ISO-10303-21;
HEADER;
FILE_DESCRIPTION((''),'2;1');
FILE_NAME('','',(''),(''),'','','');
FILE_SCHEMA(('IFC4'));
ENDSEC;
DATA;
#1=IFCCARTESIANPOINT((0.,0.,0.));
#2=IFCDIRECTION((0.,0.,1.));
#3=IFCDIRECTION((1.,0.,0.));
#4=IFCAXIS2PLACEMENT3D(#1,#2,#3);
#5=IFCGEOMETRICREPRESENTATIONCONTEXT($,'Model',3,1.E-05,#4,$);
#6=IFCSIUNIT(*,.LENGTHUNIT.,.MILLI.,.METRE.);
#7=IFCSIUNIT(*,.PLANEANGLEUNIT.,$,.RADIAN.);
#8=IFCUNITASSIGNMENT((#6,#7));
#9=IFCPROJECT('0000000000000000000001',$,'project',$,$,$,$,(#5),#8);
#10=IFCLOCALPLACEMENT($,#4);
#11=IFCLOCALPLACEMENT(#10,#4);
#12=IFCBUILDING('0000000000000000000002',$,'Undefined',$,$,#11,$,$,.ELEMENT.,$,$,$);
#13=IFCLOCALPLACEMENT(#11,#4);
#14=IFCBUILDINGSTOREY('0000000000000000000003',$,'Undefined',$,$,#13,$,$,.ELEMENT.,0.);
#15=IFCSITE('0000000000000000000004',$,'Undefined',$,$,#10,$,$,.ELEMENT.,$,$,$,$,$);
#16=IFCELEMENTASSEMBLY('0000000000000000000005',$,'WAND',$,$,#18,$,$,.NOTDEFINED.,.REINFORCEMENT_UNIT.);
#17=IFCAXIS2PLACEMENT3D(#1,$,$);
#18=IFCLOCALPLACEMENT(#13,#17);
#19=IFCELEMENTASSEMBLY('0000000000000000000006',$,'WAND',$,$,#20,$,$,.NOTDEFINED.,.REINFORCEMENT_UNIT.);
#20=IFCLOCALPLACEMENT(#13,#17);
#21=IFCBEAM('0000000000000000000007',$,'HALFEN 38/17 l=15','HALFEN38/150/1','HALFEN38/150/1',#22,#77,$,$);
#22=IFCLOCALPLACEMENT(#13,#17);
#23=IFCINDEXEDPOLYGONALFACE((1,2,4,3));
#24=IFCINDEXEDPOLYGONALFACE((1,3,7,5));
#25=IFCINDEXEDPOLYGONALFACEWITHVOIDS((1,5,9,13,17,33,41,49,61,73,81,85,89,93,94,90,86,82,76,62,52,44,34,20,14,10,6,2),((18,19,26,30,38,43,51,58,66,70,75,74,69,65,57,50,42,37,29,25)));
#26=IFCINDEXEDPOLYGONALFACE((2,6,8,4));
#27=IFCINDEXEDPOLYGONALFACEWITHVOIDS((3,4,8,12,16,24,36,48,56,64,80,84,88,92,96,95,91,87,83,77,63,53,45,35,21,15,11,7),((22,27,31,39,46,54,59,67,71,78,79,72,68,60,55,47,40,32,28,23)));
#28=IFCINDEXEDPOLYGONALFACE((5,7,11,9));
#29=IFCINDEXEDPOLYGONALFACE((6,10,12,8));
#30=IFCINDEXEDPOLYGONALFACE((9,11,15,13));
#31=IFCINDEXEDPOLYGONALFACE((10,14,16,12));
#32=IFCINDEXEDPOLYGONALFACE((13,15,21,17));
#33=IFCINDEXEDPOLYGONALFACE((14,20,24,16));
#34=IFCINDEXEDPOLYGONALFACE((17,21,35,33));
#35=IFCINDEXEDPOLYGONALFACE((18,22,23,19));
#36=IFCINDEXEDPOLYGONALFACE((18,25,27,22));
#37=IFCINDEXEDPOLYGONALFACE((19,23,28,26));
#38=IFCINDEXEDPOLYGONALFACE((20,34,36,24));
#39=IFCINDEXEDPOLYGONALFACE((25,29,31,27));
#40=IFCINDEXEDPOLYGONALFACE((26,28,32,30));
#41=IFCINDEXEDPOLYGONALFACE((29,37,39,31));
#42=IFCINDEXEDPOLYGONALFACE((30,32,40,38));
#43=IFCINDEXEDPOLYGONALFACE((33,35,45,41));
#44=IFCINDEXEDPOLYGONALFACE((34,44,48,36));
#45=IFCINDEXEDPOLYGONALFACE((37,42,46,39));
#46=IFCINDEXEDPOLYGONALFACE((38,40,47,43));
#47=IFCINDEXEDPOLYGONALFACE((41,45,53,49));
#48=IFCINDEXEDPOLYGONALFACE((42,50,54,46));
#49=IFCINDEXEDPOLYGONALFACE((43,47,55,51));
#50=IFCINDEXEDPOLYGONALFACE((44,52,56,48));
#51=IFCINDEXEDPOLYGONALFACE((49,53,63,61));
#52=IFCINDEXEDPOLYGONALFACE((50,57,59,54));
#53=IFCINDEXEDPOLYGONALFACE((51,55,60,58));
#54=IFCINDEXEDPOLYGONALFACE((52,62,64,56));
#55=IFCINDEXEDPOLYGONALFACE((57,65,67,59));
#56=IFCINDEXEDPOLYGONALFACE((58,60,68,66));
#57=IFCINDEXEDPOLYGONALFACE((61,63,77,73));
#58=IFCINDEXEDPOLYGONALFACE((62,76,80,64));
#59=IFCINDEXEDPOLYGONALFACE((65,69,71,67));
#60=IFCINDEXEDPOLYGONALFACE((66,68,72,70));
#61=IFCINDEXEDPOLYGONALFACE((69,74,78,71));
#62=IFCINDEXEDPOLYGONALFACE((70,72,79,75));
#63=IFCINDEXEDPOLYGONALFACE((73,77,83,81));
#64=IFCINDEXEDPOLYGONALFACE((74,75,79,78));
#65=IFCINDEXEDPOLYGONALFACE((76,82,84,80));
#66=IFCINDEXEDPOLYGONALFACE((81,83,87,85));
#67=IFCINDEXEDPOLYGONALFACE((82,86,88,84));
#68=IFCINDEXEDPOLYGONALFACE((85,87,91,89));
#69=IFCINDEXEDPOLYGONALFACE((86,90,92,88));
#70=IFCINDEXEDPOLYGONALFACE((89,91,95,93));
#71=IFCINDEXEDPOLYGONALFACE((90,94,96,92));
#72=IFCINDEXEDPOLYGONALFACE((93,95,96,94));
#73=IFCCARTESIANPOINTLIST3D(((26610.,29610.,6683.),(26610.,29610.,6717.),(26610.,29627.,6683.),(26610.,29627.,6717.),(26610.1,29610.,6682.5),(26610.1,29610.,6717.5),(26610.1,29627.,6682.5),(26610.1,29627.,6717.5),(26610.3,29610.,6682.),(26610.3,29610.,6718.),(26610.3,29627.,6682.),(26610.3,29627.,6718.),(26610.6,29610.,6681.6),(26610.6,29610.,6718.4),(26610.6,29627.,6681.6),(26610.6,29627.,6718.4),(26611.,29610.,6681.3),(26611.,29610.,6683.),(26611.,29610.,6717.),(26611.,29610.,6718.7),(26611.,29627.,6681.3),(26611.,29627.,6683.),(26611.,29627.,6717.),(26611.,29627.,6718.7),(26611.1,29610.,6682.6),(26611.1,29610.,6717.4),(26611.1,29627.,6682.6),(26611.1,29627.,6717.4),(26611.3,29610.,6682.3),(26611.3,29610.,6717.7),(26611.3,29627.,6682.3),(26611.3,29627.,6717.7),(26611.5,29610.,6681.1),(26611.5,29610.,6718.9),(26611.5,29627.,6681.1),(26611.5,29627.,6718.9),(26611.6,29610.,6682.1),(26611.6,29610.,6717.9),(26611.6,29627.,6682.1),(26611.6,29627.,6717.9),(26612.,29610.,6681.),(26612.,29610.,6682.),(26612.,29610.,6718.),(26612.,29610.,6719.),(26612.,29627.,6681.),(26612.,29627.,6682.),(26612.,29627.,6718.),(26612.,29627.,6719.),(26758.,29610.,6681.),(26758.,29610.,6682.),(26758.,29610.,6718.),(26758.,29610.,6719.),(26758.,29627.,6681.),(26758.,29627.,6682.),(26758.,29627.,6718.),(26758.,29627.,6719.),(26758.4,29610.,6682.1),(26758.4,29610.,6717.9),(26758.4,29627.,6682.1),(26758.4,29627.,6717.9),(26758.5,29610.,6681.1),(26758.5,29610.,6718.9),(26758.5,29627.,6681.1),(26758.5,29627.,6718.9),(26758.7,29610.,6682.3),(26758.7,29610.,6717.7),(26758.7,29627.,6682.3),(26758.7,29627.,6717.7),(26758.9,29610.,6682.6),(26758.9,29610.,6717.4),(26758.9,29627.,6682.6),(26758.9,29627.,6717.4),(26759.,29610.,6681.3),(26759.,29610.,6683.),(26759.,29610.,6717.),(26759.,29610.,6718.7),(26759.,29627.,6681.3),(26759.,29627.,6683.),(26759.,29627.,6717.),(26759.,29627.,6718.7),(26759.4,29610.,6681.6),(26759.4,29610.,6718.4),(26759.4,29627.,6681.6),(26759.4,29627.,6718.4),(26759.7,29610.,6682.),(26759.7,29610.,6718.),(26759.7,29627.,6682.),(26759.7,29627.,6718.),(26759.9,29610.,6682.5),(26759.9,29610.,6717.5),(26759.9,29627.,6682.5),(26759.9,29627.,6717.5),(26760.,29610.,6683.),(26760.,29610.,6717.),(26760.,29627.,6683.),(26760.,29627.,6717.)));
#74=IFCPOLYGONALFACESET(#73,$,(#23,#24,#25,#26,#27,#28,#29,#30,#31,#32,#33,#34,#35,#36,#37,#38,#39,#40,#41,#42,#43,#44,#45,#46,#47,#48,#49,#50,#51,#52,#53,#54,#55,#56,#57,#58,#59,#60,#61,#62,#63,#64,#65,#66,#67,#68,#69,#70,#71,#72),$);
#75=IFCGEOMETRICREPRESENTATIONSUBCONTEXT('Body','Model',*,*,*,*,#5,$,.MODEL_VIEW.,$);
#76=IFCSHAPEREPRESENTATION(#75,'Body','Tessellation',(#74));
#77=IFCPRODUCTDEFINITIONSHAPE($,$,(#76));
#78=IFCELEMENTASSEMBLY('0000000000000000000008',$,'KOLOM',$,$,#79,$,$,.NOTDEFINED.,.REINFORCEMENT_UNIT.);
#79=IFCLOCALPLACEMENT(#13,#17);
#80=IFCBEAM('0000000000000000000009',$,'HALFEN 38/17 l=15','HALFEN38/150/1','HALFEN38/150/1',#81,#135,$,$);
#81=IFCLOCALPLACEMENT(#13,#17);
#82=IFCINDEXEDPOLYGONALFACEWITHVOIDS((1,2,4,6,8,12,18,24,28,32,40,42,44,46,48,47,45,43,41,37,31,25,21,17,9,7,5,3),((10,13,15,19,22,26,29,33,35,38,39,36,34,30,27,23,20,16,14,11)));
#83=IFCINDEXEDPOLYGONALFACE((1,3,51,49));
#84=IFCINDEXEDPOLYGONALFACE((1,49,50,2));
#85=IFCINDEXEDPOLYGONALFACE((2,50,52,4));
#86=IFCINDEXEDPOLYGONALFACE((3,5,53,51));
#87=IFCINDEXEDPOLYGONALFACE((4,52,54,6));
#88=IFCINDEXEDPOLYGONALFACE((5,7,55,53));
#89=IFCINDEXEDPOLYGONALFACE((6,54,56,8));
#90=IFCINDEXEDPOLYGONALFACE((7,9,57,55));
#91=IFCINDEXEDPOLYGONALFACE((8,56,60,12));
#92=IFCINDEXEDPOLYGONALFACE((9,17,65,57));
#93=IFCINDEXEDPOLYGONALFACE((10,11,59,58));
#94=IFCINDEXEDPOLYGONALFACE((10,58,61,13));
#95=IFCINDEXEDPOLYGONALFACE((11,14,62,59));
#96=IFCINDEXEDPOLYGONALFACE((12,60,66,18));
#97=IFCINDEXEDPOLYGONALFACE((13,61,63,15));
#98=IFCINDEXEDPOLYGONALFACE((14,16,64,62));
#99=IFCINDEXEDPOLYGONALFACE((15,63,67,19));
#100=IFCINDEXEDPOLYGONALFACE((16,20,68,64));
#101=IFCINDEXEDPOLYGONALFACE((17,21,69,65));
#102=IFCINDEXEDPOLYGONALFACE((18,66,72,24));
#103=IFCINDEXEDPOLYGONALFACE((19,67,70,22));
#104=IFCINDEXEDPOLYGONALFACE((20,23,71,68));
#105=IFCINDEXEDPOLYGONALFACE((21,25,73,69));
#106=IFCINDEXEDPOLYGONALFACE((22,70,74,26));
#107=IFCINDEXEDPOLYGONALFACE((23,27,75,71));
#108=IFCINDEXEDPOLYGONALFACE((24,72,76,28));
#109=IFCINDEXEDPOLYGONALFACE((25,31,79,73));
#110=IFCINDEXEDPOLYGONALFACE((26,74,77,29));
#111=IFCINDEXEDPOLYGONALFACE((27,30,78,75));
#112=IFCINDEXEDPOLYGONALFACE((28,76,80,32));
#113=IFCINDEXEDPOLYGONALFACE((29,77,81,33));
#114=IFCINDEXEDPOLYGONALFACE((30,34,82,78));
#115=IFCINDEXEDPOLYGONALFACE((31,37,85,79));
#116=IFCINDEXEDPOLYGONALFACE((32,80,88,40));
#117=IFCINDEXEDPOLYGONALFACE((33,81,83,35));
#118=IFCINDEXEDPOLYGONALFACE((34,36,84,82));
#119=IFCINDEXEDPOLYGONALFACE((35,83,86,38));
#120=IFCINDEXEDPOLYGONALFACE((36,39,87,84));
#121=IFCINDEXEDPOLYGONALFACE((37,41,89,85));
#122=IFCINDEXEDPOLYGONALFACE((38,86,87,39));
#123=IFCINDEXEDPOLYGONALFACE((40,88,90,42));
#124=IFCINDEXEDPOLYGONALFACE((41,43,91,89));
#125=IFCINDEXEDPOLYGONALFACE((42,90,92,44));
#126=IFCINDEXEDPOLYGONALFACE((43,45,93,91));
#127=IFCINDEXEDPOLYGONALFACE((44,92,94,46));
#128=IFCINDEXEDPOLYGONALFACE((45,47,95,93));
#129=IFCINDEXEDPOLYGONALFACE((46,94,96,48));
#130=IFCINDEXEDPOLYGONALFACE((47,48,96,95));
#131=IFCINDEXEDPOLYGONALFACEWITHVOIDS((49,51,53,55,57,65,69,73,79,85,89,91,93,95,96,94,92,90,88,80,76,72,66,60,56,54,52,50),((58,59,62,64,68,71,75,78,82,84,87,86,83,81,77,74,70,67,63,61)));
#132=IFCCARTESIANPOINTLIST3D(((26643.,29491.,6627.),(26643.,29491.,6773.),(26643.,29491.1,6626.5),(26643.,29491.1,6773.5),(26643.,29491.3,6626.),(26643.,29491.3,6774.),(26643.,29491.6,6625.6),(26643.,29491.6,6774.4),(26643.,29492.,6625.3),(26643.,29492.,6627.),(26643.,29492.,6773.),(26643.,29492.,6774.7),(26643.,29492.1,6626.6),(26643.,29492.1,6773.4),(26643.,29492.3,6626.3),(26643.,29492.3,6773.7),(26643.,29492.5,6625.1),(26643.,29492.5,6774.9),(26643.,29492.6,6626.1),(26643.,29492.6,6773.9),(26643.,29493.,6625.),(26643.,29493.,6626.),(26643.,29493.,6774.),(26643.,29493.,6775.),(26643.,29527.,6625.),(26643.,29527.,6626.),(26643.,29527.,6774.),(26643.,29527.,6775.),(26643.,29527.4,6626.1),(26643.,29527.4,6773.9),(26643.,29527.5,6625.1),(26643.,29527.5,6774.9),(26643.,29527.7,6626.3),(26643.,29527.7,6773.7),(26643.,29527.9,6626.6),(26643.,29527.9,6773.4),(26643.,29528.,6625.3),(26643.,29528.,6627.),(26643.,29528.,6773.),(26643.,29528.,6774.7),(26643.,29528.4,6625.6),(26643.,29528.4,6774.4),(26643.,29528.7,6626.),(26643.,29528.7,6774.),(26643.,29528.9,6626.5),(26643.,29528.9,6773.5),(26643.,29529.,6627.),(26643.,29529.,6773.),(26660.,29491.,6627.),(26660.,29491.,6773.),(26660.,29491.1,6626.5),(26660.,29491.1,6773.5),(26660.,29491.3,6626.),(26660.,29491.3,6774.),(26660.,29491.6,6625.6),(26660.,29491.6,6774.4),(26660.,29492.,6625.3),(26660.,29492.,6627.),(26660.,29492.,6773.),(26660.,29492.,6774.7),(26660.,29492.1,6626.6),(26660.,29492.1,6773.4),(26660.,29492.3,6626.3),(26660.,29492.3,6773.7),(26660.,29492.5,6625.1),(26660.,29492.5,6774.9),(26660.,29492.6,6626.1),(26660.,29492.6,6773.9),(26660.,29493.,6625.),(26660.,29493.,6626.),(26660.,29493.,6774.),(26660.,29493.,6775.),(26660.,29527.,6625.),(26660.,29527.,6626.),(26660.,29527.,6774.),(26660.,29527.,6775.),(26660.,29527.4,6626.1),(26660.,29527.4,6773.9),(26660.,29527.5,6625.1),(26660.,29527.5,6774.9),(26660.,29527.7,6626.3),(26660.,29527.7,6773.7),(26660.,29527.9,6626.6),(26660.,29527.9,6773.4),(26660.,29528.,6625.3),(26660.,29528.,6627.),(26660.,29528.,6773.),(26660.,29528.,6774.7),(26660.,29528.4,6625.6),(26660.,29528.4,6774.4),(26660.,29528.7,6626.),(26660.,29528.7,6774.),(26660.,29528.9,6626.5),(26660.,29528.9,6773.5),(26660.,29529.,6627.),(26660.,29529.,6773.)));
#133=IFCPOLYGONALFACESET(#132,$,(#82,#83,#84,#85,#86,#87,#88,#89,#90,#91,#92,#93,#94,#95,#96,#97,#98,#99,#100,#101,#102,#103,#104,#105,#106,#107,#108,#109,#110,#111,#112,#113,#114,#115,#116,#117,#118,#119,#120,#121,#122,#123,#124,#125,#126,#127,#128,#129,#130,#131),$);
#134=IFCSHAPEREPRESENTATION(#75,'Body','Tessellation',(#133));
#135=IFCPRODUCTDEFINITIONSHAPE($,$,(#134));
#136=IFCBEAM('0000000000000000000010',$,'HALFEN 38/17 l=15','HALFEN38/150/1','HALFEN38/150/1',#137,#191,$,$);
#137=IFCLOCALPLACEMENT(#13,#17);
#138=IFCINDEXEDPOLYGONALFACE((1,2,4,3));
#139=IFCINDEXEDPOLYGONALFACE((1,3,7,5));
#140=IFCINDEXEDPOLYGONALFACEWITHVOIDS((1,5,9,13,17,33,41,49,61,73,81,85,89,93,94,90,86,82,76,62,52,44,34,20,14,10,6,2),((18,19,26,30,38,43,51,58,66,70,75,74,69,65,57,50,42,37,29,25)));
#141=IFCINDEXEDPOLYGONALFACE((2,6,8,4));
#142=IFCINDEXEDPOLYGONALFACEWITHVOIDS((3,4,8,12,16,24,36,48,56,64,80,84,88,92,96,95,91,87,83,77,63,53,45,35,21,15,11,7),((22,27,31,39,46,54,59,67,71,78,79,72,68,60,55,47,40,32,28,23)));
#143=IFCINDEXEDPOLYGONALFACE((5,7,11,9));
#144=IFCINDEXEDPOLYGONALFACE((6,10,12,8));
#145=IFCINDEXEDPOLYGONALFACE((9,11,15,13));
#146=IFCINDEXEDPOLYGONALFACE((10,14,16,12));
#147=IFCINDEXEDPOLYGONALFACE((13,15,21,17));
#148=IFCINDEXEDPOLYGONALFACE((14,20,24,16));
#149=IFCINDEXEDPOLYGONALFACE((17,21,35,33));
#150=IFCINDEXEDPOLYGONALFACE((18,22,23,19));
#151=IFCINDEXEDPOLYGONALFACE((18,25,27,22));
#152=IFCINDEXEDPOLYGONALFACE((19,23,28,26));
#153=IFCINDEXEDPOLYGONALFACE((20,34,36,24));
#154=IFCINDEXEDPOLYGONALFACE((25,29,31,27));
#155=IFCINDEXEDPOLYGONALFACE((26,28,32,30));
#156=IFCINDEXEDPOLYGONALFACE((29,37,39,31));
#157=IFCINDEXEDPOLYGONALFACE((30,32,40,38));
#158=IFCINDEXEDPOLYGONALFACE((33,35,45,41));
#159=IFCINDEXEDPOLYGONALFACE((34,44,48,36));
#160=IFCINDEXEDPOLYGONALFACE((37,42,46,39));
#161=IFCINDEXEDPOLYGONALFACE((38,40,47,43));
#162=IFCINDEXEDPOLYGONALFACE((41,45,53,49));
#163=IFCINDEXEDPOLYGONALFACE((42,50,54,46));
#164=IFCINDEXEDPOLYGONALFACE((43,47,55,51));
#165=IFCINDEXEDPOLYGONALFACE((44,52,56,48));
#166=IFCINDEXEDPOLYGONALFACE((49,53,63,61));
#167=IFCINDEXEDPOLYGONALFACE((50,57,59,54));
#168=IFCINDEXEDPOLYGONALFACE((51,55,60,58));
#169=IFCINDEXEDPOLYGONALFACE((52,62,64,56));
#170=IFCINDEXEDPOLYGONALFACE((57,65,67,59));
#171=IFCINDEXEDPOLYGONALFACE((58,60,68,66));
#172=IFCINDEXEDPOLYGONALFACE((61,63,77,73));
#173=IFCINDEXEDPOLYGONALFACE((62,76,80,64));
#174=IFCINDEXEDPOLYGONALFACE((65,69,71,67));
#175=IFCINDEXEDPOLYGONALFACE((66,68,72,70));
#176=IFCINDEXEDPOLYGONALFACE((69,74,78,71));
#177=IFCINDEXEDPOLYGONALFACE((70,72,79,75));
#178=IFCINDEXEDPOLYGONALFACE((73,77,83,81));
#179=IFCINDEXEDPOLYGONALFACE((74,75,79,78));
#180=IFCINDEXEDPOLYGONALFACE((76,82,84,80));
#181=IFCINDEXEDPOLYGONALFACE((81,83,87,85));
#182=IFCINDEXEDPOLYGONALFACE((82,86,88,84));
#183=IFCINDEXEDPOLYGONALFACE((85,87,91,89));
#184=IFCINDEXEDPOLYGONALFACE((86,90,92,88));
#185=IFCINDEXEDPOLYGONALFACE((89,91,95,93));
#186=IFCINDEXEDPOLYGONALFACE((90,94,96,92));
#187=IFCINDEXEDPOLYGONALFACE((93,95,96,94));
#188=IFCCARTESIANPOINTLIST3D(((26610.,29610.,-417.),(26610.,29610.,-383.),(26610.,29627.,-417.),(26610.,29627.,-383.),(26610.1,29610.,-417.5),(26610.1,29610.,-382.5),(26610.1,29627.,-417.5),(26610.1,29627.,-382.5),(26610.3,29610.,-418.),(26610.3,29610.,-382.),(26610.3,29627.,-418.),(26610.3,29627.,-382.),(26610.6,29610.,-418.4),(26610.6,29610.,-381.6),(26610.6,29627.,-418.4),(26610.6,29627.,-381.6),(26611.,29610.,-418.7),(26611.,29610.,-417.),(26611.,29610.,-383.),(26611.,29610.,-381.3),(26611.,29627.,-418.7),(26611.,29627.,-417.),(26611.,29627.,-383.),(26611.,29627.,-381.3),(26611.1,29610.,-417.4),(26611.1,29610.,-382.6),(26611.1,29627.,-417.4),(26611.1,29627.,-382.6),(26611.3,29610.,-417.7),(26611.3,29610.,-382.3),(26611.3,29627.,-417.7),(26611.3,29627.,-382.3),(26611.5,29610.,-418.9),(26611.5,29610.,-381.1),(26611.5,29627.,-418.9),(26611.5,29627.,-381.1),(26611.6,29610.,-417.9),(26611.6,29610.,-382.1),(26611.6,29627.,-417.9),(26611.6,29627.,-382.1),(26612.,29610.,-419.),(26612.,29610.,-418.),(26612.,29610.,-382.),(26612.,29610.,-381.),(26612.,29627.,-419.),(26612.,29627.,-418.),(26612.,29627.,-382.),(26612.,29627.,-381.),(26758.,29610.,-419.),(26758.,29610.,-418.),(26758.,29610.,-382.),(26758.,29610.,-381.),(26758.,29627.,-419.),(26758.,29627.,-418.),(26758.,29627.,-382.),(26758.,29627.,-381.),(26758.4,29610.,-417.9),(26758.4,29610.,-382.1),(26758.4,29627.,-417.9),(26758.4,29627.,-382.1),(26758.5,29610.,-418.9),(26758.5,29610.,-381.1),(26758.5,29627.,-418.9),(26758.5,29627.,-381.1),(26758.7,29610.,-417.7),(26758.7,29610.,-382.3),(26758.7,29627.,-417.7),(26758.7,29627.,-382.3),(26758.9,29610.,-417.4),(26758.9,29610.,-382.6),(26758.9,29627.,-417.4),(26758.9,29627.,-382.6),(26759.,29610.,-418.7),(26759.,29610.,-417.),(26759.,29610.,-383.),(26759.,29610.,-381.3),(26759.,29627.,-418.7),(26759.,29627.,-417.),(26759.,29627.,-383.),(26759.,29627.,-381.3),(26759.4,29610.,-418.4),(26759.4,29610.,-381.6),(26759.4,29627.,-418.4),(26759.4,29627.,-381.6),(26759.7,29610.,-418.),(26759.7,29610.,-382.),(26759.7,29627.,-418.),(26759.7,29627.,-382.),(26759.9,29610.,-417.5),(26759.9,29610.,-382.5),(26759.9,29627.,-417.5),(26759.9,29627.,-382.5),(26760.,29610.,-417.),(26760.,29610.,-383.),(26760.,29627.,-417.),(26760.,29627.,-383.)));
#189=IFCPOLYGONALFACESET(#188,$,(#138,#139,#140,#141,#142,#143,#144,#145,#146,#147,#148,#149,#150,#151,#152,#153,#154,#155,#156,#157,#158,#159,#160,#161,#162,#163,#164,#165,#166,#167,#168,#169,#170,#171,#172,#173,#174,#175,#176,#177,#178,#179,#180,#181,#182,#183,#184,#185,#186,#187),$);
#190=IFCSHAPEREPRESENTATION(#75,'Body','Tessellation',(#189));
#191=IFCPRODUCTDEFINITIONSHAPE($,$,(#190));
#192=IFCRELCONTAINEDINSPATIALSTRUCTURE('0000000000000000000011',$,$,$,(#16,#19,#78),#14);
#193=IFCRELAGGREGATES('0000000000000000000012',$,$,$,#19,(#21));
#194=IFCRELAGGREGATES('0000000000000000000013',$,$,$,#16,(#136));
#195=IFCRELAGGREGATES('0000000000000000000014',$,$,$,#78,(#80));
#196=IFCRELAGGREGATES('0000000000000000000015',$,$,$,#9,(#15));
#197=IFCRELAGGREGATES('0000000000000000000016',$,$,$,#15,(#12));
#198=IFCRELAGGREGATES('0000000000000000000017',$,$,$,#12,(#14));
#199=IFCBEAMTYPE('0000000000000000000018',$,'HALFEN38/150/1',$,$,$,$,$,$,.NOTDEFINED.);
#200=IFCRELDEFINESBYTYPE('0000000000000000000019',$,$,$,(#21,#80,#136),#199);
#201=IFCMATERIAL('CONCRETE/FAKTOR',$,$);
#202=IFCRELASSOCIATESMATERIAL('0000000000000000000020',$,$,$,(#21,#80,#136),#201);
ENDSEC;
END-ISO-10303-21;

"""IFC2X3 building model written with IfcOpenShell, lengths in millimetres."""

from ifc_helpers import new_model, si_unit, frame, frame_2d, origin_with_axes, place, context, subcontext, project, spatial, hollow_rectangle, extrude, material, type_object, element, aggregate, save


model = new_model("IFC2X3")

# Units and contexts
model_context = context("Model", 3, precision=1e-05, world=origin_with_axes())
body_context = subcontext(model_context, "Body", "Model", "MODEL_VIEW")
ifc_project = project(units=[si_unit("LENGTHUNIT", "METRE", prefix="MILLI"), si_unit("PLANEANGLEUNIT", "RADIAN")], contexts=[model_context])

# Site, building, storey
site_placement = place(None, origin_with_axes())
site = spatial("IfcSite", under=ifc_project, at=site_placement, Name="Undefined", CompositionType="ELEMENT")
building_placement = place(site_placement, origin_with_axes())
building = spatial("IfcBuilding", under=site, at=building_placement, Name="Undefined", CompositionType="ELEMENT")
storey_placement = place(building_placement, origin_with_axes())
storey = spatial("IfcBuildingStorey", under=building, at=storey_placement, Name="Undefined", CompositionType="ELEMENT", Elevation=0.0)

# Element assembly
assembly_1_placement = place(storey_placement, origin_with_axes())
assembly_1 = element("IfcElementAssembly", 1, at=assembly_1_placement, inside=storey, Name="WAND", AssemblyPlace="NOTDEFINED", PredefinedType="REINFORCEMENT_UNIT")
ifc_material_1 = material(Name="CONCRETE/FAKTOR")

# Element assemblies, beams
assembly_2_placement = place(storey_placement, origin_with_axes())
assembly_2 = element("IfcElementAssembly", 2, at=assembly_2_placement, inside=storey, Name="WAND", AssemblyPlace="NOTDEFINED", PredefinedType="REINFORCEMENT_UNIT")
beam_type_1 = type_object("IfcBeamType", Name="HALFEN38/150/1", PredefinedType="NOTDEFINED")
beam_1_placement = place(assembly_2_placement, frame((26685.0, 29610.0, 6700.0), z_axis=(0.0, 0.0, 1.0), x_axis=(0.0, 1.0, 0.0)))
beam_1 = element("IfcBeam", 3, at=beam_1_placement, type_object=beam_type_1, material=ifc_material_1, Name="HALFEN 38/17 l=15", Description="HALFEN38/150/1", ObjectType="HALFEN38/150/1", context=body_context, shape_type="SweptSolid", body=[
    extrude(hollow_rectangle(XDim=150.0, YDim=38.0, WallThickness=1.0, InnerFilletRadius=1.0, OuterFilletRadius=2.0, at=frame_2d((0.0, 0.0), x_axis=(1.0, 0.0))), frame((17.0, 0.0, 0.0), z_axis=(-1.0, 0.0, 0.0), x_axis=(0.0, -1.0, 0.0)), (0.0, 0.0, 1.0), 17.0),
])
aggregate(assembly_2, [beam_1])
assembly_3_placement = place(storey_placement, origin_with_axes())
assembly_3 = element("IfcElementAssembly", 4, at=assembly_3_placement, inside=storey, Name="KOLOM", AssemblyPlace="NOTDEFINED", PredefinedType="REINFORCEMENT_UNIT")
beam_2_placement = place(assembly_3_placement, frame((26660.0, 29510.0, 6700.0), z_axis=(0.0, -1.0, 0.0), x_axis=(-1.0, 0.0, 0.0)))
beam_2 = element("IfcBeam", 5, at=beam_2_placement, type_object=beam_type_1, material=ifc_material_1, Name="HALFEN 38/17 l=15", Description="HALFEN38/150/1", ObjectType="HALFEN38/150/1", context=body_context, shape_type="SweptSolid", body=[
    extrude(hollow_rectangle(XDim=150.0, YDim=38.0, WallThickness=1.0, InnerFilletRadius=1.0, OuterFilletRadius=2.0, at=frame_2d((0.0, 0.0), x_axis=(1.0, 0.0))), frame((17.0, 0.0, 0.0), z_axis=(-1.0, 0.0, 0.0), x_axis=(0.0, -1.0, 0.0)), (0.0, 0.0, 1.0), 17.0),
])

# Beam
beam_3_placement = place(assembly_1_placement, frame((26685.0, 29610.0, -400.0), z_axis=(0.0, 0.0, 1.0), x_axis=(0.0, 1.0, 0.0)))
beam_3 = element("IfcBeam", 6, at=beam_3_placement, type_object=beam_type_1, material=ifc_material_1, Name="HALFEN 38/17 l=15", Description="HALFEN38/150/1", ObjectType="HALFEN38/150/1", context=body_context, shape_type="SweptSolid", body=[
    extrude(hollow_rectangle(XDim=150.0, YDim=38.0, WallThickness=1.0, InnerFilletRadius=1.0, OuterFilletRadius=2.0, at=frame_2d((0.0, 0.0), x_axis=(1.0, 0.0))), frame((17.0, 0.0, 0.0), z_axis=(-1.0, 0.0, 0.0), x_axis=(0.0, -1.0, 0.0)), (0.0, 0.0, 1.0), 17.0),
])

aggregate(assembly_1, [beam_3])

aggregate(assembly_3, [beam_2])

save(model, "model.ifc")
